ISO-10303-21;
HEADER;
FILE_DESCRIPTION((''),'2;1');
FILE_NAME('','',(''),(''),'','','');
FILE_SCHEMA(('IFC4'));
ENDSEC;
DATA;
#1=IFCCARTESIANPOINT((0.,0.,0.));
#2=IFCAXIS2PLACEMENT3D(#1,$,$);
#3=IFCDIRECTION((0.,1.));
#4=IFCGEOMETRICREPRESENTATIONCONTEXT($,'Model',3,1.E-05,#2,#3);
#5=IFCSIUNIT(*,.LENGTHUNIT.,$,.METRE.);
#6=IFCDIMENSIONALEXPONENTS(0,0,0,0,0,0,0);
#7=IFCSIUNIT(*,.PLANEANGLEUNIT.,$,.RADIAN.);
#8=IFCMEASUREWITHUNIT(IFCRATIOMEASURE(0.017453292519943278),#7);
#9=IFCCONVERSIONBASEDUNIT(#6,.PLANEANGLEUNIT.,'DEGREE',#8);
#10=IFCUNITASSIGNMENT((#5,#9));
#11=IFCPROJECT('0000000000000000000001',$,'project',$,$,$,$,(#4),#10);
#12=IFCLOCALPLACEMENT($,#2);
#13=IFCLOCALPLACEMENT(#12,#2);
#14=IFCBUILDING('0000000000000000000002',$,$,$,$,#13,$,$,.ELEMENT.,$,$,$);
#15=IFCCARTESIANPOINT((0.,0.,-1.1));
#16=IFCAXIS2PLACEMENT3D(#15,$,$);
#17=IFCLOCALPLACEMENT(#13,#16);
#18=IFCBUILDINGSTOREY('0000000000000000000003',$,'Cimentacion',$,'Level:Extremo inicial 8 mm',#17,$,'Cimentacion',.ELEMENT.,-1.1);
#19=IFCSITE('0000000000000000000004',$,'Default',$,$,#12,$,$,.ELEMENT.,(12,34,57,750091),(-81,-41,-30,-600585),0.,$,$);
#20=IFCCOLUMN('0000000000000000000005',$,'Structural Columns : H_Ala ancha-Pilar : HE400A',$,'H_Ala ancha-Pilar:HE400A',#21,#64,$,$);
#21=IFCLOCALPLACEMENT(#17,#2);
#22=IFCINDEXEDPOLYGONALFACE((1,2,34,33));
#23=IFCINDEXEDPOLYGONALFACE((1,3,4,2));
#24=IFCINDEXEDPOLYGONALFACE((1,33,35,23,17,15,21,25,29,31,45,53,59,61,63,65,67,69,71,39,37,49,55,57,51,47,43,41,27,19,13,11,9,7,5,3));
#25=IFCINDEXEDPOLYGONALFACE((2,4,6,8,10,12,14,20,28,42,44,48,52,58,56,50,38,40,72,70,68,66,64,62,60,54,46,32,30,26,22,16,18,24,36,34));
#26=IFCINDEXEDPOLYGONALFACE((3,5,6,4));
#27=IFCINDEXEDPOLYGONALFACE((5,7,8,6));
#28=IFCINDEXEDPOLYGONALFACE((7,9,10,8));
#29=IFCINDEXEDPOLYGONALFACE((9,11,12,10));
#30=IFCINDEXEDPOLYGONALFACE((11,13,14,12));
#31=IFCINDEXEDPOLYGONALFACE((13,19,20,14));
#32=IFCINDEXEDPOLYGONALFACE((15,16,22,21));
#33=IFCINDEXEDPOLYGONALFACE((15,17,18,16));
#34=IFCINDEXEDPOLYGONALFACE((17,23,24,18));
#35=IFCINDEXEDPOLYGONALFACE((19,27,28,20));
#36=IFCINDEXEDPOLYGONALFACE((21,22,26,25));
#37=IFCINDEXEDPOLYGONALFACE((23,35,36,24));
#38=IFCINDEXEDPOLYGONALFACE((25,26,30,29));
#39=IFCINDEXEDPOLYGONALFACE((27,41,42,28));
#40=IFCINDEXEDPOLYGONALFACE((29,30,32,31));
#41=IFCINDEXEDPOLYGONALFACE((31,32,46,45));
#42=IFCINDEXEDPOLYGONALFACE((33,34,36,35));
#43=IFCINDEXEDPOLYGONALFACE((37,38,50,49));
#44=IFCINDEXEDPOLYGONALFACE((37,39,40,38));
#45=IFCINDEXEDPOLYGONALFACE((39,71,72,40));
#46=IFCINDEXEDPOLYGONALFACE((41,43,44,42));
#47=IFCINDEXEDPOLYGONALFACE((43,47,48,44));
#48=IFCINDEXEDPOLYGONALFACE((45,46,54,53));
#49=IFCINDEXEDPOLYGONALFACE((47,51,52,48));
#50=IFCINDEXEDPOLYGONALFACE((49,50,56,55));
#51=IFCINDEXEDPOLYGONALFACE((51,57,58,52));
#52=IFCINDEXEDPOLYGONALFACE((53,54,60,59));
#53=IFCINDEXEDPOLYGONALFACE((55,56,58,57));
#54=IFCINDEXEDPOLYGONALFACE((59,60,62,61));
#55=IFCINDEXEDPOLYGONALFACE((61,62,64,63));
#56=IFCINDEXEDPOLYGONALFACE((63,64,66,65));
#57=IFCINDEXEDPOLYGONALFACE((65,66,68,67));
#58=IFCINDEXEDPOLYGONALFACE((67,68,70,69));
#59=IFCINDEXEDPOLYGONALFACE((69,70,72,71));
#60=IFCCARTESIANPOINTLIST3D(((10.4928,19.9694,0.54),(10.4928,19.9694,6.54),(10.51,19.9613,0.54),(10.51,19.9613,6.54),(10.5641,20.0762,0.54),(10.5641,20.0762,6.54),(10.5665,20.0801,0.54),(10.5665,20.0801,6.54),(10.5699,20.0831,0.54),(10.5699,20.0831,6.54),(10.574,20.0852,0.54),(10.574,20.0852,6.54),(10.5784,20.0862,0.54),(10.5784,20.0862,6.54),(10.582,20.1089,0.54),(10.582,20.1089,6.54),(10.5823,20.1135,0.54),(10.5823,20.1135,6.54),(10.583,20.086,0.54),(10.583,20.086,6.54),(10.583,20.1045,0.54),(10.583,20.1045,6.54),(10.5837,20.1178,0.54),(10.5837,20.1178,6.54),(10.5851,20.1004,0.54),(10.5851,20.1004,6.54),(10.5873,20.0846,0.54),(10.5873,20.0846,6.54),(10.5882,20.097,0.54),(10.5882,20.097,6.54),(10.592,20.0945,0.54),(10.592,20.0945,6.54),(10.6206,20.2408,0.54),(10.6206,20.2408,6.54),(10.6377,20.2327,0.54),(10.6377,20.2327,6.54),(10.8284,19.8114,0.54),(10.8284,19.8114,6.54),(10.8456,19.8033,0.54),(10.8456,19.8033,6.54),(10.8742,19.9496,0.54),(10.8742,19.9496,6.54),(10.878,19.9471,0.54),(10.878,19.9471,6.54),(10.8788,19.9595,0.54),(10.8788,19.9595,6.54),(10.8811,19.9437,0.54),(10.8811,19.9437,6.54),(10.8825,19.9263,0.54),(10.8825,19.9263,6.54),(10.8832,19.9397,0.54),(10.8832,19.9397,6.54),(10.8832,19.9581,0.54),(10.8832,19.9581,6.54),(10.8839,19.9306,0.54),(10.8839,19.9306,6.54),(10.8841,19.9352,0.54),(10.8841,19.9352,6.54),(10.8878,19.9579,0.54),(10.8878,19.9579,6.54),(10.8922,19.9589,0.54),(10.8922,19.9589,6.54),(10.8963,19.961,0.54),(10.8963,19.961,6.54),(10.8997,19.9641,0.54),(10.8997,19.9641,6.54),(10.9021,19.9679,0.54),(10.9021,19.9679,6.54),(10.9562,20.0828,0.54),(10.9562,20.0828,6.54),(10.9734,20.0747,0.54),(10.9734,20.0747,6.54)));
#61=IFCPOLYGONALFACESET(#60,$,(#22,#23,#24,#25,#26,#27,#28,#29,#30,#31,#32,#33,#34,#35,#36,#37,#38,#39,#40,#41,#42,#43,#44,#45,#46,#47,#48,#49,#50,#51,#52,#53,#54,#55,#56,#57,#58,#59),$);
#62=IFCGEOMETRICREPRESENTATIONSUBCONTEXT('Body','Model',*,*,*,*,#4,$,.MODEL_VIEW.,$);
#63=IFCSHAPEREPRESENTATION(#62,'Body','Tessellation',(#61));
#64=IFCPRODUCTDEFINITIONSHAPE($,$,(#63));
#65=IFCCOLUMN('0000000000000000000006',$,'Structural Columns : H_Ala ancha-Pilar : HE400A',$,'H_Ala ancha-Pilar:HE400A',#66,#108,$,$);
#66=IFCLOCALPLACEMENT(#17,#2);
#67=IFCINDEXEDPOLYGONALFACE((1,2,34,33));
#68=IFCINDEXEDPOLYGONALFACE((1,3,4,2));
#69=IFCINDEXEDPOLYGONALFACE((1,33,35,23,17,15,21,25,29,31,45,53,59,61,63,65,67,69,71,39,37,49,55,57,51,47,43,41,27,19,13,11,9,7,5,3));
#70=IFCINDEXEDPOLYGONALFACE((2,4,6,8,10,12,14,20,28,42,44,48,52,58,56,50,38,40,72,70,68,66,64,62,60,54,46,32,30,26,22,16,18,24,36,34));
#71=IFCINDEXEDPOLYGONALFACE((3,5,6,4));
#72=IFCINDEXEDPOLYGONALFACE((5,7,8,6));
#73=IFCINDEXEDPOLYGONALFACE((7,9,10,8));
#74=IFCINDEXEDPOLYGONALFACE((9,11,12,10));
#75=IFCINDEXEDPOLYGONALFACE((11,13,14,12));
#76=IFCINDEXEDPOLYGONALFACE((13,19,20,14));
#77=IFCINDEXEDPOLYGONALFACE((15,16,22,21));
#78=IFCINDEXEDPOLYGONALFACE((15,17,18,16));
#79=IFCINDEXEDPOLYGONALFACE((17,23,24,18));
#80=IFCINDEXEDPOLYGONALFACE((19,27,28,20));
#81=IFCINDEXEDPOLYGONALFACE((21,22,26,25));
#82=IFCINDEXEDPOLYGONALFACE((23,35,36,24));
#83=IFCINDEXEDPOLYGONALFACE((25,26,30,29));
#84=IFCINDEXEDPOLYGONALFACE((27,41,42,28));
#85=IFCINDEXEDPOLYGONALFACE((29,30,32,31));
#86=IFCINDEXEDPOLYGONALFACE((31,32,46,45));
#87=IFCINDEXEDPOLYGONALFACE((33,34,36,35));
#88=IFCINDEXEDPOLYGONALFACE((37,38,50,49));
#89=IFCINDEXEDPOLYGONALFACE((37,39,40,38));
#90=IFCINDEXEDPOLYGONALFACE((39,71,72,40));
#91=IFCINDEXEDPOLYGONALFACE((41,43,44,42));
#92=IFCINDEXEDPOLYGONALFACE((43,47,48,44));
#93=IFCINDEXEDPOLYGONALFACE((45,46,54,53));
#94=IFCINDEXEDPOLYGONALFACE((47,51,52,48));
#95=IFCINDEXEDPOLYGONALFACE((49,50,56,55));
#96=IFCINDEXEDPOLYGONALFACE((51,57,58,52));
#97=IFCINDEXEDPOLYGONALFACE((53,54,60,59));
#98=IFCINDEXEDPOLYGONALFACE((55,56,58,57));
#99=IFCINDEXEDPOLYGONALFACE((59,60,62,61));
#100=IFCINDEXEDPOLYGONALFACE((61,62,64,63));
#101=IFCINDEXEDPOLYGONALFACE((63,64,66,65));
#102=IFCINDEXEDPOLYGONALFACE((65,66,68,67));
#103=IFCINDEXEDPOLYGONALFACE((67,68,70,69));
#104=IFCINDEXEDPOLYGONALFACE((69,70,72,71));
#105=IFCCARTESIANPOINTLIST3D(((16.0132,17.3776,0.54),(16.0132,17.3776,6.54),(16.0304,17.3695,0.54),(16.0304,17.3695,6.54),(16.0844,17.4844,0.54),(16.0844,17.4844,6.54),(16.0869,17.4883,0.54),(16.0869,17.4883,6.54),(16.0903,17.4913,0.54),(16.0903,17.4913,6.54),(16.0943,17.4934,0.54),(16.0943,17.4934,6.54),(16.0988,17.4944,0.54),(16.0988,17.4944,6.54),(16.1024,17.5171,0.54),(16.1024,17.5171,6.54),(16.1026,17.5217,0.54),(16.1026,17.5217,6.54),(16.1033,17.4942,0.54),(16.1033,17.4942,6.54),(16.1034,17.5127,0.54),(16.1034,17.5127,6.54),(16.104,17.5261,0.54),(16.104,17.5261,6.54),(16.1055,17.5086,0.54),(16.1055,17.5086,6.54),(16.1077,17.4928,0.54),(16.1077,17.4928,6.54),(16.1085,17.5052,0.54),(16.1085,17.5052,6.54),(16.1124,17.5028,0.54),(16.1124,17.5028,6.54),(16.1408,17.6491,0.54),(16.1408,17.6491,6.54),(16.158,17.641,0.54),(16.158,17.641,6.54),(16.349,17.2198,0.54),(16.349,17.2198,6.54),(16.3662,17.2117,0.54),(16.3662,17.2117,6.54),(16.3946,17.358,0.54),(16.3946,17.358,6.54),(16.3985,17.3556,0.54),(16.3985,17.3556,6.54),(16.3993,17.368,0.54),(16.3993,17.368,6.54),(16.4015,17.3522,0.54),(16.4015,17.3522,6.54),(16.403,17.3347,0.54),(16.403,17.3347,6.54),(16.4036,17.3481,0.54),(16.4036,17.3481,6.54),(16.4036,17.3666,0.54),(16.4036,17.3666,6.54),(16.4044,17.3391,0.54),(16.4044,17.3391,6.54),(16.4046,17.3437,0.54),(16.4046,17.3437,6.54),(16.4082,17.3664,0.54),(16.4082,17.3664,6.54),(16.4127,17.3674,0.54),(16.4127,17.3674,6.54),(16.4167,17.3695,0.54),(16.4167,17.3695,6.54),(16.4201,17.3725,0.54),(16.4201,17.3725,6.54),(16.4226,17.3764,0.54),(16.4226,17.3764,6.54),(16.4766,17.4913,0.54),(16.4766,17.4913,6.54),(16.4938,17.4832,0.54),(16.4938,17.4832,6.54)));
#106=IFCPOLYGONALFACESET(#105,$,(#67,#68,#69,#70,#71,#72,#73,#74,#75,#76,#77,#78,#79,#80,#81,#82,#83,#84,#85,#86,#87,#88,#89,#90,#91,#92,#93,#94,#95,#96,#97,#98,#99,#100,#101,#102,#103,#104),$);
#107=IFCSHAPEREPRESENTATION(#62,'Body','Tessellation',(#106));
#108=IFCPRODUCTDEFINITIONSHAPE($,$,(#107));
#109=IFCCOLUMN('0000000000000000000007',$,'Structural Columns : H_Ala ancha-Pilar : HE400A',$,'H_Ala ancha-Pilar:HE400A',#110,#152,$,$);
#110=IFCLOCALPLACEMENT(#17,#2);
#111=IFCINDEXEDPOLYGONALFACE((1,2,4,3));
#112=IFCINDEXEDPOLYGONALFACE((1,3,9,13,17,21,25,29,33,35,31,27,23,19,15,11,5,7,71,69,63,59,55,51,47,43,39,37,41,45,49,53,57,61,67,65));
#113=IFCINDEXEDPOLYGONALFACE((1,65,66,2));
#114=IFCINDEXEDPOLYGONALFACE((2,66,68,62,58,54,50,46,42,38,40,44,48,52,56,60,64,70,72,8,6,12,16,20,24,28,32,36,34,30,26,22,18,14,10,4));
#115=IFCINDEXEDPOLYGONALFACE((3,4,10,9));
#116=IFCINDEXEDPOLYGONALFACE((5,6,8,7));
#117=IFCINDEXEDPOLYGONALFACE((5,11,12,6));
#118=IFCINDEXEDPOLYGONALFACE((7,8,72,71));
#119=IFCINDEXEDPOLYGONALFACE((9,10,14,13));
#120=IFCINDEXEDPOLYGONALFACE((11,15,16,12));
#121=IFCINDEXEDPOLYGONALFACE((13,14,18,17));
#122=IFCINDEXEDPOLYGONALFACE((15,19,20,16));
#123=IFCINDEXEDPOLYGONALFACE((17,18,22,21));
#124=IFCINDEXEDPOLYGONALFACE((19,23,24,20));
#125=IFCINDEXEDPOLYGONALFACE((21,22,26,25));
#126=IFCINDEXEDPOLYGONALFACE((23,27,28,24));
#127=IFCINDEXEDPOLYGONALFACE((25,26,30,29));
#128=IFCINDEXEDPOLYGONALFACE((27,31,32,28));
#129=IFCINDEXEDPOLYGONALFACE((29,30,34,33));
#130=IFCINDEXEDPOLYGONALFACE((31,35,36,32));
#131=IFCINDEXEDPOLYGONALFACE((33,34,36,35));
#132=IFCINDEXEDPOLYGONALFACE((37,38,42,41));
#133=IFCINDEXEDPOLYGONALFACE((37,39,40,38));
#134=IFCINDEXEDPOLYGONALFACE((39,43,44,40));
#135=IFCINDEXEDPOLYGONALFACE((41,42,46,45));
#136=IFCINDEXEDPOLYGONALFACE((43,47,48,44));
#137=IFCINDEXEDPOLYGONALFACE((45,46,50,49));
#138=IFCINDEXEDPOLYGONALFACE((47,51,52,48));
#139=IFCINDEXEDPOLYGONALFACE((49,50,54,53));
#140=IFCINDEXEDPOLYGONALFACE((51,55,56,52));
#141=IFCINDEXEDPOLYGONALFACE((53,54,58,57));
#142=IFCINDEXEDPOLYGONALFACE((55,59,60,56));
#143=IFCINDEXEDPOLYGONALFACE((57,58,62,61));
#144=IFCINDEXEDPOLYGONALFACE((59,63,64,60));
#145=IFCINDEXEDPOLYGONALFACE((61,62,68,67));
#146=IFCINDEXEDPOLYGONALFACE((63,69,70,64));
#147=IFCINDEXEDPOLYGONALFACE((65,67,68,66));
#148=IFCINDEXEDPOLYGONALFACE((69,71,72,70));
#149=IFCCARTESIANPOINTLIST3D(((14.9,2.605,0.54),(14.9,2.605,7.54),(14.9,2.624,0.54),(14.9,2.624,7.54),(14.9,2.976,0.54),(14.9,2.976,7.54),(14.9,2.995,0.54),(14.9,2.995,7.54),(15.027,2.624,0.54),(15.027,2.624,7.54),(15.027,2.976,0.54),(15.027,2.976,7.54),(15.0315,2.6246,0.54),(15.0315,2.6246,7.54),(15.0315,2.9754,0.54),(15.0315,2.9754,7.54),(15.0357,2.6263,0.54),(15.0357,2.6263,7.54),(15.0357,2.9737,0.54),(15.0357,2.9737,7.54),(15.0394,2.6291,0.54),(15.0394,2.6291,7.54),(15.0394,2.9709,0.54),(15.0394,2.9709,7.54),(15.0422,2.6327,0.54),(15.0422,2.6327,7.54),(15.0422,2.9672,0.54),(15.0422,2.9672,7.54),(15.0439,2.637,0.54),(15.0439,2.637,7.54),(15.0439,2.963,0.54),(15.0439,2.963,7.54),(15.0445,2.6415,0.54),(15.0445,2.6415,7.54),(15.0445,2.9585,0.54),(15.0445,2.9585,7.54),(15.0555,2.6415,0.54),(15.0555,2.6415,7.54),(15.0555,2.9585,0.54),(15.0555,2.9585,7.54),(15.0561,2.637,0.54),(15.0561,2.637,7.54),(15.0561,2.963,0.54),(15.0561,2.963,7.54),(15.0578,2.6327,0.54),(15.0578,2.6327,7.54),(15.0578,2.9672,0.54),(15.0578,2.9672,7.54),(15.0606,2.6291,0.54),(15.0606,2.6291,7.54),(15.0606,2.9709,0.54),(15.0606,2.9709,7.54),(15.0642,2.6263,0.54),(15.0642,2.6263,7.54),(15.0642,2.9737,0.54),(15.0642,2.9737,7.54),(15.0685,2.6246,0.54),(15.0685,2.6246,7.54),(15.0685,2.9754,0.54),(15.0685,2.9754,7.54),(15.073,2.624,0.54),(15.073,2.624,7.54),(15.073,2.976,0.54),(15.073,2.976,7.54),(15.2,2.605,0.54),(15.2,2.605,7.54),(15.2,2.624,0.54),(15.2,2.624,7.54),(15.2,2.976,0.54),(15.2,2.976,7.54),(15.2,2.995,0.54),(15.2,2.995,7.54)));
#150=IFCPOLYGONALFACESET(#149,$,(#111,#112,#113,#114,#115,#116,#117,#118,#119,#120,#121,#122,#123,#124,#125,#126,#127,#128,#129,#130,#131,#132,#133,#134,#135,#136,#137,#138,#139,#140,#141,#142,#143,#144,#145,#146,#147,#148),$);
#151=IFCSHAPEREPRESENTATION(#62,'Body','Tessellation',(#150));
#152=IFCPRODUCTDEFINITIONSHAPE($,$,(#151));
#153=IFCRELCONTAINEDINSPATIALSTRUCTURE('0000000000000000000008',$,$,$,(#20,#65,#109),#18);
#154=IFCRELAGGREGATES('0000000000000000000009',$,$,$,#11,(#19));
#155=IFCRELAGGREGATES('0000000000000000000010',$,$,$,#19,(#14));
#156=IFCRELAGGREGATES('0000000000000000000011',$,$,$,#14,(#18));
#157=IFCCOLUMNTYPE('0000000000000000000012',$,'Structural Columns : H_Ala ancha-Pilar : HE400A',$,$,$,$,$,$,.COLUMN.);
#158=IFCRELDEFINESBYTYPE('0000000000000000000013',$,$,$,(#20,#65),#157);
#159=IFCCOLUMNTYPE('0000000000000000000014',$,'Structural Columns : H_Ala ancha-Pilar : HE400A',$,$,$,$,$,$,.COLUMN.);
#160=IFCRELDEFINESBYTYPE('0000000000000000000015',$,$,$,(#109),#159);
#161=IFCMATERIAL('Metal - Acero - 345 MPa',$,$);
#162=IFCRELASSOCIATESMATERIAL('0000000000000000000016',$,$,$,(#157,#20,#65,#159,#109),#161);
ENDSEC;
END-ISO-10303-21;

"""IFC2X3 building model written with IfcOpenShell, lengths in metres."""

from ifc_helpers import new_model, entity, si_unit, converted_unit, direction, frame, frame_2d, origin, place, context, subcontext, project, spatial, polyline, circle_curve, parameter, trimmed, segment, composite_curve, outline, extrude, source, transform, mapped, material, type_object, type_shapes, element, save


model = new_model("IFC2X3")

# Units and contexts
model_context = context("Model", 3, precision=1e-05, world=origin(), true_north=direction((0.0, 1.0)))
body_context = subcontext(model_context, "Body", "Model", "MODEL_VIEW")
ifc_project = project(units=[si_unit("LENGTHUNIT", "METRE"), converted_unit("PLANEANGLEUNIT", "DEGREE", entity("IfcRatioMeasure", 0.017453292519943278), si_unit("PLANEANGLEUNIT", "RADIAN"), dimensions=[0, 0, 0, 0, 0, 0, 0])], contexts=[model_context])

# Site, building, storey
site_placement = place(None, origin())
site = spatial("IfcSite", under=ifc_project, at=site_placement, Name="Default", CompositionType="ELEMENT", RefLatitude=(12, 34, 57, 750091), RefLongitude=(-81, -41, -30, -600585), RefElevation=0.0)
building_placement = place(site_placement, origin())
building = spatial("IfcBuilding", under=site, at=building_placement, CompositionType="ELEMENT")
storey_placement = place(building_placement, frame((0.0, 0.0, -1.1)))
storey = spatial("IfcBuildingStorey", under=building, at=storey_placement, Name="Cimentacion", ObjectType="Level:Extremo inicial 8 mm", LongName="Cimentacion", CompositionType="ELEMENT", Elevation=-1.1)

# Columns
ifc_material = material(Name="Metal - Acero - 345 MPa")
column_type_1 = type_object("IfcColumnType", Name="Structural Columns : H_Ala ancha-Pilar : HE400A", PredefinedType="COLUMN", material=ifc_material)
shared_shape_1 = source(origin(), body_context, "Body", "SweptSolid", [
    extrude(outline(composite_curve([segment(polyline([(0.176, -0.15), (0.195, -0.15)]), True, "CONTINUOUS"), segment(polyline([(0.195, -0.15), (0.195, 0.15)]), True, "CONTINUOUS"), segment(polyline([(0.195, 0.15), (0.176, 0.15)]), True, "CONTINUOUS"), segment(polyline([(0.176, 0.15), (0.176, 0.023)]), True, "CONTINUOUS"), segment(trimmed(circle_curve(frame_2d((0.1585, 0.023), x_axis=(1.0, 0.0)), 0.0175), [parameter(270.0)], [parameter(0.0)], True, "PARAMETER"), False, "CONTINUOUS"), segment(polyline([(0.1585, 0.0055), (-0.1585, 0.0055)]), True, "CONTINUOUS"), segment(trimmed(circle_curve(frame_2d((-0.1585, 0.023), x_axis=(0.0, -1.0)), 0.0175), [parameter(270.0)], [parameter(0.0)], True, "PARAMETER"), False, "CONTINUOUS"), segment(polyline([(-0.176, 0.023), (-0.176, 0.15)]), True, "CONTINUOUS"), segment(polyline([(-0.176, 0.15), (-0.195, 0.15)]), True, "CONTINUOUS"), segment(polyline([(-0.195, 0.15), (-0.195, -0.15)]), True, "CONTINUOUS"), segment(polyline([(-0.195, -0.15), (-0.176, -0.15)]), True, "CONTINUOUS"), segment(polyline([(-0.176, -0.15), (-0.176, -0.023)]), True, "CONTINUOUS"), segment(trimmed(circle_curve(frame_2d((-0.1585, -0.023), x_axis=(-1.0, 0.0)), 0.0175), [parameter(270.0)], [parameter(0.0)], True, "PARAMETER"), False, "CONTINUOUS"), segment(polyline([(-0.1585, -0.0055), (0.1585, -0.0055)]), True, "CONTINUOUS"), segment(trimmed(circle_curve(frame_2d((0.1585, -0.023), x_axis=(0.0, 1.0)), 0.0175), [parameter(270.0)], [parameter(0.0)], True, "PARAMETER"), False, "CONTINUOUS"), segment(polyline([(0.176, -0.023), (0.176, -0.15)]), True, "CONTINUOUS")], self_intersect=False)), frame((0.0, 0.0, -0.56), z_axis=(0.0, 0.0, 1.0), x_axis=(0.0, -1.0, 0.0)), (0.0, 0.0, 1.0), 6.0),
])
type_shapes(column_type_1, [shared_shape_1])
for number, where, z_axis, x_axis, name in (
    (1, (10.7331, 20.0221, 1.1), (0.0, 0.0, 1.0), (0.425906, 0.904768, 0.0), "Structural Columns : H_Ala ancha-Pilar : HE400A"),
    (2, (16.2535, 17.4304, 1.1), (0.0, 0.0, 1.0), (0.425223, 0.905088, 0.0), "Structural Columns : H_Ala ancha-Pilar : HE400A"),
):
    element("IfcColumn", number, at=place(storey_placement, frame(where, z_axis=z_axis, x_axis=x_axis)), inside=storey, type_object=column_type_1, material=ifc_material, Name=name, ObjectType="H_Ala ancha-Pilar:HE400A", context=body_context, shape_type="MappedRepresentation", body=[
        mapped(shared_shape_1, transform((0.0, 0.0, 0.0), scale=1.0)),
    ])
column_type_2 = type_object("IfcColumnType", Name="Structural Columns : H_Ala ancha-Pilar : HE400A", PredefinedType="COLUMN", material=ifc_material)
shared_shape_2 = source(origin(), body_context, "Body", "SweptSolid", [
    extrude(outline(composite_curve([segment(polyline([(0.176, -0.15), (0.195, -0.15)]), True, "CONTINUOUS"), segment(polyline([(0.195, -0.15), (0.195, 0.15)]), True, "CONTINUOUS"), segment(polyline([(0.195, 0.15), (0.176, 0.15)]), True, "CONTINUOUS"), segment(polyline([(0.176, 0.15), (0.176, 0.023)]), True, "CONTINUOUS"), segment(trimmed(circle_curve(frame_2d((0.1585, 0.023), x_axis=(1.0, 0.0)), 0.0175), [parameter(270.0)], [parameter(0.0)], True, "PARAMETER"), False, "CONTINUOUS"), segment(polyline([(0.1585, 0.0055), (-0.1585, 0.0055)]), True, "CONTINUOUS"), segment(trimmed(circle_curve(frame_2d((-0.1585, 0.023), x_axis=(0.0, -1.0)), 0.0175), [parameter(270.0)], [parameter(0.0)], True, "PARAMETER"), False, "CONTINUOUS"), segment(polyline([(-0.176, 0.023), (-0.176, 0.15)]), True, "CONTINUOUS"), segment(polyline([(-0.176, 0.15), (-0.195, 0.15)]), True, "CONTINUOUS"), segment(polyline([(-0.195, 0.15), (-0.195, -0.15)]), True, "CONTINUOUS"), segment(polyline([(-0.195, -0.15), (-0.176, -0.15)]), True, "CONTINUOUS"), segment(polyline([(-0.176, -0.15), (-0.176, -0.023)]), True, "CONTINUOUS"), segment(trimmed(circle_curve(frame_2d((-0.1585, -0.023), x_axis=(-1.0, 0.0)), 0.0175), [parameter(270.0)], [parameter(0.0)], True, "PARAMETER"), False, "CONTINUOUS"), segment(polyline([(-0.1585, -0.0055), (0.1585, -0.0055)]), True, "CONTINUOUS"), segment(trimmed(circle_curve(frame_2d((0.1585, -0.023), x_axis=(0.0, 1.0)), 0.0175), [parameter(270.0)], [parameter(0.0)], True, "PARAMETER"), False, "CONTINUOUS"), segment(polyline([(0.176, -0.023), (0.176, -0.15)]), True, "CONTINUOUS")], self_intersect=False)), frame((0.0, 0.0, -0.56), z_axis=(0.0, 0.0, 1.0), x_axis=(0.0, -1.0, 0.0)), (0.0, 0.0, 1.0), 7.0),
])
type_shapes(column_type_2, [shared_shape_2])
for number, where, z_axis, x_axis, name in (
    (3, (15.05, 2.8, 1.1), (0.0, 0.0, 1.0), (-1.0, 0.0, 0.0), "Structural Columns : H_Ala ancha-Pilar : HE400A"),
):
    element("IfcColumn", number, at=place(storey_placement, frame(where, z_axis=z_axis, x_axis=x_axis)), inside=storey, type_object=column_type_2, material=ifc_material, Name=name, ObjectType="H_Ala ancha-Pilar:HE400A", context=body_context, shape_type="MappedRepresentation", body=[
        mapped(shared_shape_2, transform((0.0, 0.0, 0.0), scale=1.0)),
    ])

save(model, "model.ifc")
